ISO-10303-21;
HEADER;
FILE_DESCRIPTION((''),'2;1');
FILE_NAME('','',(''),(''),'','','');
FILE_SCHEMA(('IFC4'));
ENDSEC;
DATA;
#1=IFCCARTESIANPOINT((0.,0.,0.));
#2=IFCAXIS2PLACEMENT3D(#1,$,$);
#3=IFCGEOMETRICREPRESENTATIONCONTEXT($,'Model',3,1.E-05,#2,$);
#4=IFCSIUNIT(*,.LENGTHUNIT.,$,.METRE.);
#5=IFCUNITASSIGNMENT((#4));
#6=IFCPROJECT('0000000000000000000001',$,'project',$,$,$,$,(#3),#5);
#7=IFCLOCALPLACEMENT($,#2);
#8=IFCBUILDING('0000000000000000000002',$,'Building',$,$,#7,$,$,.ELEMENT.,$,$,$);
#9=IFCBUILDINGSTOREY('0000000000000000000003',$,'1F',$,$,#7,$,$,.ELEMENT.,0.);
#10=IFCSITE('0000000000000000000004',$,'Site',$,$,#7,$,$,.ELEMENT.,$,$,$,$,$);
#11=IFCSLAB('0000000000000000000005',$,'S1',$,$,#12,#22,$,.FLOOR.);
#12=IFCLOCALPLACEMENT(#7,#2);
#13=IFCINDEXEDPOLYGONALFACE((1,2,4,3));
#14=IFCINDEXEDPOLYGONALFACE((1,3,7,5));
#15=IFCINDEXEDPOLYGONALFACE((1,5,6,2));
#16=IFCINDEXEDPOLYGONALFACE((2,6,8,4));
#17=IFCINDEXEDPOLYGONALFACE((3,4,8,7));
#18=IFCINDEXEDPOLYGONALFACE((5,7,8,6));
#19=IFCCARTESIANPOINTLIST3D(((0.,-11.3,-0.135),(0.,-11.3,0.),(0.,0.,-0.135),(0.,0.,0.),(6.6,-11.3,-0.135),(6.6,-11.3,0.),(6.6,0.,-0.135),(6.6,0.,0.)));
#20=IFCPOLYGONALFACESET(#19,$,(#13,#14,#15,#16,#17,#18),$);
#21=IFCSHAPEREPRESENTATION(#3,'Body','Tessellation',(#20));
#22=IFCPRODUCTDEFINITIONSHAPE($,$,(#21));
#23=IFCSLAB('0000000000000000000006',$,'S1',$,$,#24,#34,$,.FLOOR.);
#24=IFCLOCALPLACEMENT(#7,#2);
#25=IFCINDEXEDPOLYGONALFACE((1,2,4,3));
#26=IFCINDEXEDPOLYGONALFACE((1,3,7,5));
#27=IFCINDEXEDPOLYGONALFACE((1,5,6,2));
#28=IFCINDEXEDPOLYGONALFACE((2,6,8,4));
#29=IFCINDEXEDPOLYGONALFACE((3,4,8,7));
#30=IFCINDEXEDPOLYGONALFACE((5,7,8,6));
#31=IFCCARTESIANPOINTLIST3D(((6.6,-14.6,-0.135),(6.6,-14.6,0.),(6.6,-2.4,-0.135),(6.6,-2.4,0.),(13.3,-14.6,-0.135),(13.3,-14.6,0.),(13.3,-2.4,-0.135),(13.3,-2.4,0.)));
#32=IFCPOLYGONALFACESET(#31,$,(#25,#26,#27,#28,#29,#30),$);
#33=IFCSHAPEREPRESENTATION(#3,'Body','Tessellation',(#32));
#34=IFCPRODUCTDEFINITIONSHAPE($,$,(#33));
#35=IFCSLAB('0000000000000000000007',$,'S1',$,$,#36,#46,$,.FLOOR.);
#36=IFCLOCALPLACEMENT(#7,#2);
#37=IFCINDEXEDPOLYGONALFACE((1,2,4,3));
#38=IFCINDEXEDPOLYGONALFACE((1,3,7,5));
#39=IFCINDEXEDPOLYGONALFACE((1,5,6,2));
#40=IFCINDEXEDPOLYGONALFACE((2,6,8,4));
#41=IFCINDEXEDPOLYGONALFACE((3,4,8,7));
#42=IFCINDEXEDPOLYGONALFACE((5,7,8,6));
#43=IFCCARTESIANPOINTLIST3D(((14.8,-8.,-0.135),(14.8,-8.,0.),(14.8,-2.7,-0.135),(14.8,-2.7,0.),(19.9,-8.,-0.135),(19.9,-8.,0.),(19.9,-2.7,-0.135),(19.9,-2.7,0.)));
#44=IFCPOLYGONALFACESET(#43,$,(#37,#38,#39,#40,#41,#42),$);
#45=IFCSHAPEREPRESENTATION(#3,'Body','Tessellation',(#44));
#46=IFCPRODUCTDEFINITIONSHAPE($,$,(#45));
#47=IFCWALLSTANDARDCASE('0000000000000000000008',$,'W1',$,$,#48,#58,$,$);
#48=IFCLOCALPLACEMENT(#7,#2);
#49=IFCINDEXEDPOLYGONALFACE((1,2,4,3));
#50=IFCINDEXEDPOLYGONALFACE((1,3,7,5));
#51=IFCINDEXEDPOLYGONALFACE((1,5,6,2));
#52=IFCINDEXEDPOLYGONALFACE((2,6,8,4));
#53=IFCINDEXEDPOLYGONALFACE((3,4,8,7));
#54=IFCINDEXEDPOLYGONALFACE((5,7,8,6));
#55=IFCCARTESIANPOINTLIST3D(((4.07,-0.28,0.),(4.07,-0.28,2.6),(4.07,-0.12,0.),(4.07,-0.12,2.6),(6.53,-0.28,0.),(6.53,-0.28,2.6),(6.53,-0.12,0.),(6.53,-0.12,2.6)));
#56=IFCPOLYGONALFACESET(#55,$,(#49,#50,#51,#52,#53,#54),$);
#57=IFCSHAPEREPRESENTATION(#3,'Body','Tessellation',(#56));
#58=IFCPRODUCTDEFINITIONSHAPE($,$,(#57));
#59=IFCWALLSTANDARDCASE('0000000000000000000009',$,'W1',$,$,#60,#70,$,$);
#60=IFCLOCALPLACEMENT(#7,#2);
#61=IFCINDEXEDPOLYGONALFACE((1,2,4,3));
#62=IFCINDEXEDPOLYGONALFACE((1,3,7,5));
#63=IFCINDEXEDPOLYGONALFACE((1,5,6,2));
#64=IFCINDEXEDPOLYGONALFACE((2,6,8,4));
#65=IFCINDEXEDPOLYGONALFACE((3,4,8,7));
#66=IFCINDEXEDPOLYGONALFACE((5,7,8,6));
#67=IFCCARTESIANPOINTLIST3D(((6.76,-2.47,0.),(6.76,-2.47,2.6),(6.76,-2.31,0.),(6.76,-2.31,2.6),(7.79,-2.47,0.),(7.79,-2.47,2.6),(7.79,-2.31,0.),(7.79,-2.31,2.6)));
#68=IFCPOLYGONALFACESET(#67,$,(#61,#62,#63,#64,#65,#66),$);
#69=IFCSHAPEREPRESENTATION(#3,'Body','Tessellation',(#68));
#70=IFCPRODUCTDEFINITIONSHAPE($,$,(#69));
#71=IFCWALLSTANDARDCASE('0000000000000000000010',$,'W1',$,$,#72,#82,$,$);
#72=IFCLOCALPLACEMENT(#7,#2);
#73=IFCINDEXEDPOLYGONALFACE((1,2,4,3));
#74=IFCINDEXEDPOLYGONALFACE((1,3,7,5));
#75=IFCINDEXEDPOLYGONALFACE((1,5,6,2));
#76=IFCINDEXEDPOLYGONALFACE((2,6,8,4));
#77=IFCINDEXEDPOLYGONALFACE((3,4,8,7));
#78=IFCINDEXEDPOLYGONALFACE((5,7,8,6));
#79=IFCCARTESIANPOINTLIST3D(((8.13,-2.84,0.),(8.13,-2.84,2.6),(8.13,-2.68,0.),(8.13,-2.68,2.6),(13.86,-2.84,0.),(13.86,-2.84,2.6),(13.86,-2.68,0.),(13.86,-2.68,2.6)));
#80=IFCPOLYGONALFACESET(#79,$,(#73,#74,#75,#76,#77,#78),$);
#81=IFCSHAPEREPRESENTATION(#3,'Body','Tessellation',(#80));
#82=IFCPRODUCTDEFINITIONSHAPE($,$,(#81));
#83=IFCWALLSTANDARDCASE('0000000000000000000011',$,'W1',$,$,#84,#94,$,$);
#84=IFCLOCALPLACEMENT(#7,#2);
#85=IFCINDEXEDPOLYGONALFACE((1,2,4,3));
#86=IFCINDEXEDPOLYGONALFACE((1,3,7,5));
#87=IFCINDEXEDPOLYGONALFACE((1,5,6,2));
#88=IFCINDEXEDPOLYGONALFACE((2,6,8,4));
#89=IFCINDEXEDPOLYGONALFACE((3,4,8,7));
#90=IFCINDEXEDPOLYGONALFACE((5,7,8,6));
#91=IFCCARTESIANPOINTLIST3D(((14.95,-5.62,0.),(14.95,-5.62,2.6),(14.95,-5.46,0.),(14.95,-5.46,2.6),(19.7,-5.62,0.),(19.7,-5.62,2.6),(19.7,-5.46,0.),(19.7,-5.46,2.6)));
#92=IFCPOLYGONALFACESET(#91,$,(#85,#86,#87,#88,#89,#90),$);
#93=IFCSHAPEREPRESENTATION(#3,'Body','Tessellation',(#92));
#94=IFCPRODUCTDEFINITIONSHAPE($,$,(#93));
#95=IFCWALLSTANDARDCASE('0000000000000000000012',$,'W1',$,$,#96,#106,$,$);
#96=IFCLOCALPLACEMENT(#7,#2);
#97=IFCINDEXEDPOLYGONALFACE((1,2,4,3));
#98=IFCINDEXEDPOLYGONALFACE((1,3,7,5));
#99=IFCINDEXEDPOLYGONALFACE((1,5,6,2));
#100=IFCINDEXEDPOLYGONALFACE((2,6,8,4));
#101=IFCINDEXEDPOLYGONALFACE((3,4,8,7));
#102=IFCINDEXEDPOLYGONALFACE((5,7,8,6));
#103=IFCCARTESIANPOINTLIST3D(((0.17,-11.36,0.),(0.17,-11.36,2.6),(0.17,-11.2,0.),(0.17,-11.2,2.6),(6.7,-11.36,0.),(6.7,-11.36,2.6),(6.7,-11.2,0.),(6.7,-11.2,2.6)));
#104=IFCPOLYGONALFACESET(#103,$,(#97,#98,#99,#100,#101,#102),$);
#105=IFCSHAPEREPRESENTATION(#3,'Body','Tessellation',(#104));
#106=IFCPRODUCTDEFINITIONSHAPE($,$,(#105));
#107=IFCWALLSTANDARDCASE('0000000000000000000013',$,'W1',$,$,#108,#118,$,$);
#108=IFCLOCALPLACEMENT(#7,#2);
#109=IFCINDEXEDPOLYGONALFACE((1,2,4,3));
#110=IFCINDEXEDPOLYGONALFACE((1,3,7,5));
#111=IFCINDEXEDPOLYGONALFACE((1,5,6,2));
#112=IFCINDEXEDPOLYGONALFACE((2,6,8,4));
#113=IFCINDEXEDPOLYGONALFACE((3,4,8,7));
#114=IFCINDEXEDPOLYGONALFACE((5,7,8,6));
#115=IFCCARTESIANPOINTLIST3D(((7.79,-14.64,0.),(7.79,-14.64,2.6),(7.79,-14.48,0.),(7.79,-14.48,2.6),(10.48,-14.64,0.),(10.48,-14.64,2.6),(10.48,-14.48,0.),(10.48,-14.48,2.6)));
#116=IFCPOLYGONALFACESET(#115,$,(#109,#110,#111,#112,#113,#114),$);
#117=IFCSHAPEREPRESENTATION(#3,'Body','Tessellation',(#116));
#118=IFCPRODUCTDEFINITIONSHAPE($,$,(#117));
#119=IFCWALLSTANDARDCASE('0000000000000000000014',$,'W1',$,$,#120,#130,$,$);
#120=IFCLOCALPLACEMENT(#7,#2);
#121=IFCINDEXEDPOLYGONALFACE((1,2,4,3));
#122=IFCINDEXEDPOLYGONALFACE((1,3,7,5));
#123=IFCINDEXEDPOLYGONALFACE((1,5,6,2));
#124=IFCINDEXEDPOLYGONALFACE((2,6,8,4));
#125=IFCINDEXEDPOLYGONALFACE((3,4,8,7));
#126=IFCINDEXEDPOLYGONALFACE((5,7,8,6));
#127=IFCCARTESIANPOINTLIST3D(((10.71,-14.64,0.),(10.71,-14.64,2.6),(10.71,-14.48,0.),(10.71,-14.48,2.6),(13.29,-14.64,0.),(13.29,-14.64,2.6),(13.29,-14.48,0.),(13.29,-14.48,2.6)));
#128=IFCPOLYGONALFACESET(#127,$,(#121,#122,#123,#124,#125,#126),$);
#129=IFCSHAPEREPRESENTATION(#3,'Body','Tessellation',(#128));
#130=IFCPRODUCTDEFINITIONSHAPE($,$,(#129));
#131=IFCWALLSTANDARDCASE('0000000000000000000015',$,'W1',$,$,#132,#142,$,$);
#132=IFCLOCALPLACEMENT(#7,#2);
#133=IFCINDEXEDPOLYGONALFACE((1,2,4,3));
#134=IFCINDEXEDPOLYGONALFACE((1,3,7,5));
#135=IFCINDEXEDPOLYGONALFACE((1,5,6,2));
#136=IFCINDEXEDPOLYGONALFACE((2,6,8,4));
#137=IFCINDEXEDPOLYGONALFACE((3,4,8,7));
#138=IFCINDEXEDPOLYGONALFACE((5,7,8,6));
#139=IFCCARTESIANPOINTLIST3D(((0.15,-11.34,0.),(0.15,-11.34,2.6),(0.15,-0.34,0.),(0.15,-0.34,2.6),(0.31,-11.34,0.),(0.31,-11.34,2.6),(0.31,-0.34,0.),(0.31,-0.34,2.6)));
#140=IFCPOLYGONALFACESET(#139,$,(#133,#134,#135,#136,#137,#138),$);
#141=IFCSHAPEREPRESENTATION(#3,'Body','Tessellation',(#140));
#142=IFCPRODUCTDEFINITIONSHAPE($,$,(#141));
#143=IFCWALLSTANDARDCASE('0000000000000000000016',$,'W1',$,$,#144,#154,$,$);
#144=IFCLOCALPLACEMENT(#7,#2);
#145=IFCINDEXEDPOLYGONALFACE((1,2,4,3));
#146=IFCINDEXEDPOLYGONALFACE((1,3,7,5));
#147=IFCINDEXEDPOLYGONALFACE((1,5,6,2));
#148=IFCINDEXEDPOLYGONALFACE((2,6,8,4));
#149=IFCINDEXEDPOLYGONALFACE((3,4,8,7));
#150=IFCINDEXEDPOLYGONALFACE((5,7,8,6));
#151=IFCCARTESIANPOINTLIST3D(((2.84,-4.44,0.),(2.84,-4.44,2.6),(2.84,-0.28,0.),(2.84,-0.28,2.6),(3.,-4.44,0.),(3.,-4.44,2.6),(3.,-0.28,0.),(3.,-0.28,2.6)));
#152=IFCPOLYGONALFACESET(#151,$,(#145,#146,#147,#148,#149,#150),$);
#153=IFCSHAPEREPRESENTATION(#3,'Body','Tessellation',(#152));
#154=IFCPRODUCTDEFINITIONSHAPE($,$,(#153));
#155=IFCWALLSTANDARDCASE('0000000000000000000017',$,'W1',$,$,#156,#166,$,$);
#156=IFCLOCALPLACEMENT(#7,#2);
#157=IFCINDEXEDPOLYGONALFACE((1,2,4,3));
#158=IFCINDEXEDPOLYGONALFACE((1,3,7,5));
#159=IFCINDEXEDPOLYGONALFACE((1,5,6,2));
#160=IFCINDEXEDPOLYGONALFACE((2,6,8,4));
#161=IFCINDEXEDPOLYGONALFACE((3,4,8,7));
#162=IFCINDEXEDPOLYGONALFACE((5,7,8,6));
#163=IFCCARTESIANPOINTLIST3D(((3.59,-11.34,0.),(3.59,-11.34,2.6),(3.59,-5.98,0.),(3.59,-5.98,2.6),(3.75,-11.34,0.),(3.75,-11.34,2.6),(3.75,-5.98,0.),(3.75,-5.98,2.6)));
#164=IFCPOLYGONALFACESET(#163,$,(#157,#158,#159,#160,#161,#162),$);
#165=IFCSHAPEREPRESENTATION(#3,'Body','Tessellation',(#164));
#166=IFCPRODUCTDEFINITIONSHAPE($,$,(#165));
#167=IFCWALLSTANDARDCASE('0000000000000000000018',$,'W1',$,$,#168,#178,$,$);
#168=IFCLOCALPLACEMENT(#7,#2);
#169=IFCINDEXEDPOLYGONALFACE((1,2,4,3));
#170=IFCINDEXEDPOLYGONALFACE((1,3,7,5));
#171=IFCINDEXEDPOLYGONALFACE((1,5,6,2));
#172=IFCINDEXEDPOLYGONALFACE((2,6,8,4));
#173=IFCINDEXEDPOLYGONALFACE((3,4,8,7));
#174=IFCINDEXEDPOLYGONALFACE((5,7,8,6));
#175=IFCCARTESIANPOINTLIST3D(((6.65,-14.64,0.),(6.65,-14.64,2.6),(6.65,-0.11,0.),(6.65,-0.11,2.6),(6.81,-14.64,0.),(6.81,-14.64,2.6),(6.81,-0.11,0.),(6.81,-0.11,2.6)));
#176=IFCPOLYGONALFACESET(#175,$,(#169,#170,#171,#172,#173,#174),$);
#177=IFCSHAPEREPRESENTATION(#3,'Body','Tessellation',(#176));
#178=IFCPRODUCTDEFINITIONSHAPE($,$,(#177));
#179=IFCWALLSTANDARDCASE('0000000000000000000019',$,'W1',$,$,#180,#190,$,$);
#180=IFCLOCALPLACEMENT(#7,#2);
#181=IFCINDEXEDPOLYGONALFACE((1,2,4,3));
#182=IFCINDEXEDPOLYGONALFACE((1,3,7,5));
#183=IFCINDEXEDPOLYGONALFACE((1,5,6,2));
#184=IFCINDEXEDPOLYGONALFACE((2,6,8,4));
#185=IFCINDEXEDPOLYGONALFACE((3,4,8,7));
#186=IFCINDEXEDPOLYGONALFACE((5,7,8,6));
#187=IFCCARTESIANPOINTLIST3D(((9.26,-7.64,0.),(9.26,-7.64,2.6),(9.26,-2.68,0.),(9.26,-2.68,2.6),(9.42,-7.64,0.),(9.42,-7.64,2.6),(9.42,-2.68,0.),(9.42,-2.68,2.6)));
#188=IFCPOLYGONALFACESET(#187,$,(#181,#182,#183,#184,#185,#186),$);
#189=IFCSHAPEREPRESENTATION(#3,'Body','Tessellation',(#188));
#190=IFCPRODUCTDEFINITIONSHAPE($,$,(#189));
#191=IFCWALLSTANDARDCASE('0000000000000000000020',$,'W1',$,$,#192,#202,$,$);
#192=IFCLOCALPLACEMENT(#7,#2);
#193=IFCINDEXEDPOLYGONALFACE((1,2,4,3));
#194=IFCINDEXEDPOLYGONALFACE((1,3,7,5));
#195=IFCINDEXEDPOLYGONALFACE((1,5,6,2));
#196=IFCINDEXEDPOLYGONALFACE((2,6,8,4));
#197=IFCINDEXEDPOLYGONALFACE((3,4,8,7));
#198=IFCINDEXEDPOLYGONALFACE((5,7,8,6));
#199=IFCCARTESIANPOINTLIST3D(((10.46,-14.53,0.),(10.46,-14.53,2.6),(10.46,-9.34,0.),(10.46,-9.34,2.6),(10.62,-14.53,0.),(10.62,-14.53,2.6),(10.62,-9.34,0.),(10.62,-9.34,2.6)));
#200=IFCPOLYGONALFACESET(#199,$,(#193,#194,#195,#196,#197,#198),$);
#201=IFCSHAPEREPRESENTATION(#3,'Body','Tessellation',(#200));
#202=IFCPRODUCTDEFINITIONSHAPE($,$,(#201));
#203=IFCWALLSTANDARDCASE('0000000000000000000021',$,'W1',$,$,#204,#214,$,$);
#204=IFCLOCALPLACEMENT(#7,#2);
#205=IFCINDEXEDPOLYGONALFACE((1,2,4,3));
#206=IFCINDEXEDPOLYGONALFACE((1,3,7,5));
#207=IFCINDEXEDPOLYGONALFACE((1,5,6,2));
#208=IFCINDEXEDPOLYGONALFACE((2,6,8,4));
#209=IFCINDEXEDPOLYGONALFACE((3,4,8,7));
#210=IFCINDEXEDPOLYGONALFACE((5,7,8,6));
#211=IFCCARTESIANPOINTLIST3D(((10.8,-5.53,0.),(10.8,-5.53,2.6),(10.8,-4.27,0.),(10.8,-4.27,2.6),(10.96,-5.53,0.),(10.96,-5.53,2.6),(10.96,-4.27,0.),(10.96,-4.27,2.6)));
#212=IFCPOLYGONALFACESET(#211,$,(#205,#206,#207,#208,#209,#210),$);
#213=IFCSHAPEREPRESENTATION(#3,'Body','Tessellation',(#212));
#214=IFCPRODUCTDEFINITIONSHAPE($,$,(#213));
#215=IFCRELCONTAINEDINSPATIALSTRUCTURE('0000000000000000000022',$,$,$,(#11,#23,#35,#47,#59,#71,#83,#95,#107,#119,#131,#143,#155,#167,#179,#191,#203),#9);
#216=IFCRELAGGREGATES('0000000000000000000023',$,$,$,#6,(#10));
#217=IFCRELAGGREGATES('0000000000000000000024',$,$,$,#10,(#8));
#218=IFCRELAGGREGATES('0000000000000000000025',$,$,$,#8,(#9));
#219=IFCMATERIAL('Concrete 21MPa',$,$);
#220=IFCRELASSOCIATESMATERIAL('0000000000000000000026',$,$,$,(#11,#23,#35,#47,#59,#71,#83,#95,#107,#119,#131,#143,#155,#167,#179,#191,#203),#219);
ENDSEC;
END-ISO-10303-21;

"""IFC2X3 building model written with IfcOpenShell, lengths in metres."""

from ifc_helpers import new_model, si_unit, frame, origin, origin_2d, place, context, project, spatial, rectangle, extrude, material, element, save


model = new_model("IFC2X3")

# Units and contexts
model_context = context("Model", 3, precision=1e-05, world=origin())
ifc_project = project(units=[si_unit("LENGTHUNIT", "METRE")], contexts=[model_context])

# Site, building, storey
placement = place(None, origin())
site = spatial("IfcSite", under=ifc_project, at=placement, Name="Site", CompositionType="ELEMENT")
building = spatial("IfcBuilding", under=site, at=placement, Name="Building", CompositionType="ELEMENT")
storey = spatial("IfcBuildingStorey", under=building, at=placement, Name="1F", CompositionType="ELEMENT", Elevation=0.0)

# Slabs
ifc_material_1 = material(Name="Concrete 21MPa")
slab_1_placement = place(None, frame((3.3, -5.65, -0.135)))
element("IfcSlab", 1, at=slab_1_placement, inside=storey, material=ifc_material_1, Name="S1", PredefinedType="FLOOR", context=model_context, shape_type="SweptSolid", body=[
    extrude(rectangle(XDim=6.6, YDim=11.3, at=origin_2d()), origin(), (0.0, 0.0, 1.0), 0.135),
])
slab_2_placement = place(None, frame((9.95, -8.5, -0.135)))
element("IfcSlab", 2, at=slab_2_placement, inside=storey, material=ifc_material_1, Name="S1", PredefinedType="FLOOR", context=model_context, shape_type="SweptSolid", body=[
    extrude(rectangle(XDim=6.7, YDim=12.2, at=origin_2d()), origin(), (0.0, 0.0, 1.0), 0.135),
])
slab_3_placement = place(None, frame((17.35, -5.35, -0.135)))
element("IfcSlab", 3, at=slab_3_placement, inside=storey, material=ifc_material_1, Name="S1", PredefinedType="FLOOR", context=model_context, shape_type="SweptSolid", body=[
    extrude(rectangle(XDim=5.1, YDim=5.3, at=origin_2d()), origin(), (0.0, 0.0, 1.0), 0.135),
])

# Walls
wall_1_placement = place(None, frame((5.3, -0.2, 0.0)))
element("IfcWallStandardCase", 4, at=wall_1_placement, inside=storey, material=ifc_material_1, Name="W1", context=model_context, shape_type="SweptSolid", body=[
    extrude(rectangle(XDim=2.46, YDim=0.16, at=origin_2d()), origin(), (0.0, 0.0, 1.0), 2.6),
])
wall_2_placement = place(None, frame((7.275, -2.39, 0.0)))
element("IfcWallStandardCase", 5, at=wall_2_placement, inside=storey, material=ifc_material_1, Name="W1", context=model_context, shape_type="SweptSolid", body=[
    extrude(rectangle(XDim=1.03, YDim=0.16, at=origin_2d()), origin(), (0.0, 0.0, 1.0), 2.6),
])
wall_3_placement = place(None, frame((10.995, -2.76, 0.0)))
element("IfcWallStandardCase", 6, at=wall_3_placement, inside=storey, material=ifc_material_1, Name="W1", context=model_context, shape_type="SweptSolid", body=[
    extrude(rectangle(XDim=5.73, YDim=0.16, at=origin_2d()), origin(), (0.0, 0.0, 1.0), 2.6),
])
wall_4_placement = place(None, frame((17.325, -5.54, 0.0)))
element("IfcWallStandardCase", 7, at=wall_4_placement, inside=storey, material=ifc_material_1, Name="W1", context=model_context, shape_type="SweptSolid", body=[
    extrude(rectangle(XDim=4.75, YDim=0.16, at=origin_2d()), origin(), (0.0, 0.0, 1.0), 2.6),
])
wall_5_placement = place(None, frame((3.435, -11.28, 0.0)))
element("IfcWallStandardCase", 8, at=wall_5_placement, inside=storey, material=ifc_material_1, Name="W1", context=model_context, shape_type="SweptSolid", body=[
    extrude(rectangle(XDim=6.53, YDim=0.16, at=origin_2d()), origin(), (0.0, 0.0, 1.0), 2.6),
])
wall_6_placement = place(None, frame((9.135, -14.56, 0.0)))
element("IfcWallStandardCase", 9, at=wall_6_placement, inside=storey, material=ifc_material_1, Name="W1", context=model_context, shape_type="SweptSolid", body=[
    extrude(rectangle(XDim=2.69, YDim=0.16, at=origin_2d()), origin(), (0.0, 0.0, 1.0), 2.6),
])
wall_7_placement = place(None, frame((12.0, -14.56, 0.0)))
element("IfcWallStandardCase", 10, at=wall_7_placement, inside=storey, material=ifc_material_1, Name="W1", context=model_context, shape_type="SweptSolid", body=[
    extrude(rectangle(XDim=2.58, YDim=0.16, at=origin_2d()), origin(), (0.0, 0.0, 1.0), 2.6),
])
wall_8_placement = place(None, frame((0.23, -5.84, 0.0)))
element("IfcWallStandardCase", 11, at=wall_8_placement, inside=storey, material=ifc_material_1, Name="W1", context=model_context, shape_type="SweptSolid", body=[
    extrude(rectangle(XDim=0.16, YDim=11.0, at=origin_2d()), origin(), (0.0, 0.0, 1.0), 2.6),
])
wall_9_placement = place(None, frame((2.92, -2.36, 0.0)))
element("IfcWallStandardCase", 12, at=wall_9_placement, inside=storey, material=ifc_material_1, Name="W1", context=model_context, shape_type="SweptSolid", body=[
    extrude(rectangle(XDim=0.16, YDim=4.16, at=origin_2d()), origin(), (0.0, 0.0, 1.0), 2.6),
])
wall_10_placement = place(None, frame((3.67, -8.66, 0.0)))
element("IfcWallStandardCase", 13, at=wall_10_placement, inside=storey, material=ifc_material_1, Name="W1", context=model_context, shape_type="SweptSolid", body=[
    extrude(rectangle(XDim=0.16, YDim=5.36, at=origin_2d()), origin(), (0.0, 0.0, 1.0), 2.6),
])
wall_11_placement = place(None, frame((6.73, -7.375, 0.0)))
element("IfcWallStandardCase", 14, at=wall_11_placement, inside=storey, material=ifc_material_1, Name="W1", context=model_context, shape_type="SweptSolid", body=[
    extrude(rectangle(XDim=0.16, YDim=14.53, at=origin_2d()), origin(), (0.0, 0.0, 1.0), 2.6),
])
wall_12_placement = place(None, frame((9.34, -5.16, 0.0)))
element("IfcWallStandardCase", 15, at=wall_12_placement, inside=storey, material=ifc_material_1, Name="W1", context=model_context, shape_type="SweptSolid", body=[
    extrude(rectangle(XDim=0.16, YDim=4.96, at=origin_2d()), origin(), (0.0, 0.0, 1.0), 2.6),
])
wall_13_placement = place(None, frame((10.54, -11.935, 0.0)))
element("IfcWallStandardCase", 16, at=wall_13_placement, inside=storey, material=ifc_material_1, Name="W1", context=model_context, shape_type="SweptSolid", body=[
    extrude(rectangle(XDim=0.16, YDim=5.19, at=origin_2d()), origin(), (0.0, 0.0, 1.0), 2.6),
])
wall_14_placement = place(None, frame((10.88, -4.9, 0.0)))
element("IfcWallStandardCase", 17, at=wall_14_placement, inside=storey, material=ifc_material_1, Name="W1", context=model_context, shape_type="SweptSolid", body=[
    extrude(rectangle(XDim=0.16, YDim=1.26, at=origin_2d()), origin(), (0.0, 0.0, 1.0), 2.6),
])

save(model, "model.ifc")
